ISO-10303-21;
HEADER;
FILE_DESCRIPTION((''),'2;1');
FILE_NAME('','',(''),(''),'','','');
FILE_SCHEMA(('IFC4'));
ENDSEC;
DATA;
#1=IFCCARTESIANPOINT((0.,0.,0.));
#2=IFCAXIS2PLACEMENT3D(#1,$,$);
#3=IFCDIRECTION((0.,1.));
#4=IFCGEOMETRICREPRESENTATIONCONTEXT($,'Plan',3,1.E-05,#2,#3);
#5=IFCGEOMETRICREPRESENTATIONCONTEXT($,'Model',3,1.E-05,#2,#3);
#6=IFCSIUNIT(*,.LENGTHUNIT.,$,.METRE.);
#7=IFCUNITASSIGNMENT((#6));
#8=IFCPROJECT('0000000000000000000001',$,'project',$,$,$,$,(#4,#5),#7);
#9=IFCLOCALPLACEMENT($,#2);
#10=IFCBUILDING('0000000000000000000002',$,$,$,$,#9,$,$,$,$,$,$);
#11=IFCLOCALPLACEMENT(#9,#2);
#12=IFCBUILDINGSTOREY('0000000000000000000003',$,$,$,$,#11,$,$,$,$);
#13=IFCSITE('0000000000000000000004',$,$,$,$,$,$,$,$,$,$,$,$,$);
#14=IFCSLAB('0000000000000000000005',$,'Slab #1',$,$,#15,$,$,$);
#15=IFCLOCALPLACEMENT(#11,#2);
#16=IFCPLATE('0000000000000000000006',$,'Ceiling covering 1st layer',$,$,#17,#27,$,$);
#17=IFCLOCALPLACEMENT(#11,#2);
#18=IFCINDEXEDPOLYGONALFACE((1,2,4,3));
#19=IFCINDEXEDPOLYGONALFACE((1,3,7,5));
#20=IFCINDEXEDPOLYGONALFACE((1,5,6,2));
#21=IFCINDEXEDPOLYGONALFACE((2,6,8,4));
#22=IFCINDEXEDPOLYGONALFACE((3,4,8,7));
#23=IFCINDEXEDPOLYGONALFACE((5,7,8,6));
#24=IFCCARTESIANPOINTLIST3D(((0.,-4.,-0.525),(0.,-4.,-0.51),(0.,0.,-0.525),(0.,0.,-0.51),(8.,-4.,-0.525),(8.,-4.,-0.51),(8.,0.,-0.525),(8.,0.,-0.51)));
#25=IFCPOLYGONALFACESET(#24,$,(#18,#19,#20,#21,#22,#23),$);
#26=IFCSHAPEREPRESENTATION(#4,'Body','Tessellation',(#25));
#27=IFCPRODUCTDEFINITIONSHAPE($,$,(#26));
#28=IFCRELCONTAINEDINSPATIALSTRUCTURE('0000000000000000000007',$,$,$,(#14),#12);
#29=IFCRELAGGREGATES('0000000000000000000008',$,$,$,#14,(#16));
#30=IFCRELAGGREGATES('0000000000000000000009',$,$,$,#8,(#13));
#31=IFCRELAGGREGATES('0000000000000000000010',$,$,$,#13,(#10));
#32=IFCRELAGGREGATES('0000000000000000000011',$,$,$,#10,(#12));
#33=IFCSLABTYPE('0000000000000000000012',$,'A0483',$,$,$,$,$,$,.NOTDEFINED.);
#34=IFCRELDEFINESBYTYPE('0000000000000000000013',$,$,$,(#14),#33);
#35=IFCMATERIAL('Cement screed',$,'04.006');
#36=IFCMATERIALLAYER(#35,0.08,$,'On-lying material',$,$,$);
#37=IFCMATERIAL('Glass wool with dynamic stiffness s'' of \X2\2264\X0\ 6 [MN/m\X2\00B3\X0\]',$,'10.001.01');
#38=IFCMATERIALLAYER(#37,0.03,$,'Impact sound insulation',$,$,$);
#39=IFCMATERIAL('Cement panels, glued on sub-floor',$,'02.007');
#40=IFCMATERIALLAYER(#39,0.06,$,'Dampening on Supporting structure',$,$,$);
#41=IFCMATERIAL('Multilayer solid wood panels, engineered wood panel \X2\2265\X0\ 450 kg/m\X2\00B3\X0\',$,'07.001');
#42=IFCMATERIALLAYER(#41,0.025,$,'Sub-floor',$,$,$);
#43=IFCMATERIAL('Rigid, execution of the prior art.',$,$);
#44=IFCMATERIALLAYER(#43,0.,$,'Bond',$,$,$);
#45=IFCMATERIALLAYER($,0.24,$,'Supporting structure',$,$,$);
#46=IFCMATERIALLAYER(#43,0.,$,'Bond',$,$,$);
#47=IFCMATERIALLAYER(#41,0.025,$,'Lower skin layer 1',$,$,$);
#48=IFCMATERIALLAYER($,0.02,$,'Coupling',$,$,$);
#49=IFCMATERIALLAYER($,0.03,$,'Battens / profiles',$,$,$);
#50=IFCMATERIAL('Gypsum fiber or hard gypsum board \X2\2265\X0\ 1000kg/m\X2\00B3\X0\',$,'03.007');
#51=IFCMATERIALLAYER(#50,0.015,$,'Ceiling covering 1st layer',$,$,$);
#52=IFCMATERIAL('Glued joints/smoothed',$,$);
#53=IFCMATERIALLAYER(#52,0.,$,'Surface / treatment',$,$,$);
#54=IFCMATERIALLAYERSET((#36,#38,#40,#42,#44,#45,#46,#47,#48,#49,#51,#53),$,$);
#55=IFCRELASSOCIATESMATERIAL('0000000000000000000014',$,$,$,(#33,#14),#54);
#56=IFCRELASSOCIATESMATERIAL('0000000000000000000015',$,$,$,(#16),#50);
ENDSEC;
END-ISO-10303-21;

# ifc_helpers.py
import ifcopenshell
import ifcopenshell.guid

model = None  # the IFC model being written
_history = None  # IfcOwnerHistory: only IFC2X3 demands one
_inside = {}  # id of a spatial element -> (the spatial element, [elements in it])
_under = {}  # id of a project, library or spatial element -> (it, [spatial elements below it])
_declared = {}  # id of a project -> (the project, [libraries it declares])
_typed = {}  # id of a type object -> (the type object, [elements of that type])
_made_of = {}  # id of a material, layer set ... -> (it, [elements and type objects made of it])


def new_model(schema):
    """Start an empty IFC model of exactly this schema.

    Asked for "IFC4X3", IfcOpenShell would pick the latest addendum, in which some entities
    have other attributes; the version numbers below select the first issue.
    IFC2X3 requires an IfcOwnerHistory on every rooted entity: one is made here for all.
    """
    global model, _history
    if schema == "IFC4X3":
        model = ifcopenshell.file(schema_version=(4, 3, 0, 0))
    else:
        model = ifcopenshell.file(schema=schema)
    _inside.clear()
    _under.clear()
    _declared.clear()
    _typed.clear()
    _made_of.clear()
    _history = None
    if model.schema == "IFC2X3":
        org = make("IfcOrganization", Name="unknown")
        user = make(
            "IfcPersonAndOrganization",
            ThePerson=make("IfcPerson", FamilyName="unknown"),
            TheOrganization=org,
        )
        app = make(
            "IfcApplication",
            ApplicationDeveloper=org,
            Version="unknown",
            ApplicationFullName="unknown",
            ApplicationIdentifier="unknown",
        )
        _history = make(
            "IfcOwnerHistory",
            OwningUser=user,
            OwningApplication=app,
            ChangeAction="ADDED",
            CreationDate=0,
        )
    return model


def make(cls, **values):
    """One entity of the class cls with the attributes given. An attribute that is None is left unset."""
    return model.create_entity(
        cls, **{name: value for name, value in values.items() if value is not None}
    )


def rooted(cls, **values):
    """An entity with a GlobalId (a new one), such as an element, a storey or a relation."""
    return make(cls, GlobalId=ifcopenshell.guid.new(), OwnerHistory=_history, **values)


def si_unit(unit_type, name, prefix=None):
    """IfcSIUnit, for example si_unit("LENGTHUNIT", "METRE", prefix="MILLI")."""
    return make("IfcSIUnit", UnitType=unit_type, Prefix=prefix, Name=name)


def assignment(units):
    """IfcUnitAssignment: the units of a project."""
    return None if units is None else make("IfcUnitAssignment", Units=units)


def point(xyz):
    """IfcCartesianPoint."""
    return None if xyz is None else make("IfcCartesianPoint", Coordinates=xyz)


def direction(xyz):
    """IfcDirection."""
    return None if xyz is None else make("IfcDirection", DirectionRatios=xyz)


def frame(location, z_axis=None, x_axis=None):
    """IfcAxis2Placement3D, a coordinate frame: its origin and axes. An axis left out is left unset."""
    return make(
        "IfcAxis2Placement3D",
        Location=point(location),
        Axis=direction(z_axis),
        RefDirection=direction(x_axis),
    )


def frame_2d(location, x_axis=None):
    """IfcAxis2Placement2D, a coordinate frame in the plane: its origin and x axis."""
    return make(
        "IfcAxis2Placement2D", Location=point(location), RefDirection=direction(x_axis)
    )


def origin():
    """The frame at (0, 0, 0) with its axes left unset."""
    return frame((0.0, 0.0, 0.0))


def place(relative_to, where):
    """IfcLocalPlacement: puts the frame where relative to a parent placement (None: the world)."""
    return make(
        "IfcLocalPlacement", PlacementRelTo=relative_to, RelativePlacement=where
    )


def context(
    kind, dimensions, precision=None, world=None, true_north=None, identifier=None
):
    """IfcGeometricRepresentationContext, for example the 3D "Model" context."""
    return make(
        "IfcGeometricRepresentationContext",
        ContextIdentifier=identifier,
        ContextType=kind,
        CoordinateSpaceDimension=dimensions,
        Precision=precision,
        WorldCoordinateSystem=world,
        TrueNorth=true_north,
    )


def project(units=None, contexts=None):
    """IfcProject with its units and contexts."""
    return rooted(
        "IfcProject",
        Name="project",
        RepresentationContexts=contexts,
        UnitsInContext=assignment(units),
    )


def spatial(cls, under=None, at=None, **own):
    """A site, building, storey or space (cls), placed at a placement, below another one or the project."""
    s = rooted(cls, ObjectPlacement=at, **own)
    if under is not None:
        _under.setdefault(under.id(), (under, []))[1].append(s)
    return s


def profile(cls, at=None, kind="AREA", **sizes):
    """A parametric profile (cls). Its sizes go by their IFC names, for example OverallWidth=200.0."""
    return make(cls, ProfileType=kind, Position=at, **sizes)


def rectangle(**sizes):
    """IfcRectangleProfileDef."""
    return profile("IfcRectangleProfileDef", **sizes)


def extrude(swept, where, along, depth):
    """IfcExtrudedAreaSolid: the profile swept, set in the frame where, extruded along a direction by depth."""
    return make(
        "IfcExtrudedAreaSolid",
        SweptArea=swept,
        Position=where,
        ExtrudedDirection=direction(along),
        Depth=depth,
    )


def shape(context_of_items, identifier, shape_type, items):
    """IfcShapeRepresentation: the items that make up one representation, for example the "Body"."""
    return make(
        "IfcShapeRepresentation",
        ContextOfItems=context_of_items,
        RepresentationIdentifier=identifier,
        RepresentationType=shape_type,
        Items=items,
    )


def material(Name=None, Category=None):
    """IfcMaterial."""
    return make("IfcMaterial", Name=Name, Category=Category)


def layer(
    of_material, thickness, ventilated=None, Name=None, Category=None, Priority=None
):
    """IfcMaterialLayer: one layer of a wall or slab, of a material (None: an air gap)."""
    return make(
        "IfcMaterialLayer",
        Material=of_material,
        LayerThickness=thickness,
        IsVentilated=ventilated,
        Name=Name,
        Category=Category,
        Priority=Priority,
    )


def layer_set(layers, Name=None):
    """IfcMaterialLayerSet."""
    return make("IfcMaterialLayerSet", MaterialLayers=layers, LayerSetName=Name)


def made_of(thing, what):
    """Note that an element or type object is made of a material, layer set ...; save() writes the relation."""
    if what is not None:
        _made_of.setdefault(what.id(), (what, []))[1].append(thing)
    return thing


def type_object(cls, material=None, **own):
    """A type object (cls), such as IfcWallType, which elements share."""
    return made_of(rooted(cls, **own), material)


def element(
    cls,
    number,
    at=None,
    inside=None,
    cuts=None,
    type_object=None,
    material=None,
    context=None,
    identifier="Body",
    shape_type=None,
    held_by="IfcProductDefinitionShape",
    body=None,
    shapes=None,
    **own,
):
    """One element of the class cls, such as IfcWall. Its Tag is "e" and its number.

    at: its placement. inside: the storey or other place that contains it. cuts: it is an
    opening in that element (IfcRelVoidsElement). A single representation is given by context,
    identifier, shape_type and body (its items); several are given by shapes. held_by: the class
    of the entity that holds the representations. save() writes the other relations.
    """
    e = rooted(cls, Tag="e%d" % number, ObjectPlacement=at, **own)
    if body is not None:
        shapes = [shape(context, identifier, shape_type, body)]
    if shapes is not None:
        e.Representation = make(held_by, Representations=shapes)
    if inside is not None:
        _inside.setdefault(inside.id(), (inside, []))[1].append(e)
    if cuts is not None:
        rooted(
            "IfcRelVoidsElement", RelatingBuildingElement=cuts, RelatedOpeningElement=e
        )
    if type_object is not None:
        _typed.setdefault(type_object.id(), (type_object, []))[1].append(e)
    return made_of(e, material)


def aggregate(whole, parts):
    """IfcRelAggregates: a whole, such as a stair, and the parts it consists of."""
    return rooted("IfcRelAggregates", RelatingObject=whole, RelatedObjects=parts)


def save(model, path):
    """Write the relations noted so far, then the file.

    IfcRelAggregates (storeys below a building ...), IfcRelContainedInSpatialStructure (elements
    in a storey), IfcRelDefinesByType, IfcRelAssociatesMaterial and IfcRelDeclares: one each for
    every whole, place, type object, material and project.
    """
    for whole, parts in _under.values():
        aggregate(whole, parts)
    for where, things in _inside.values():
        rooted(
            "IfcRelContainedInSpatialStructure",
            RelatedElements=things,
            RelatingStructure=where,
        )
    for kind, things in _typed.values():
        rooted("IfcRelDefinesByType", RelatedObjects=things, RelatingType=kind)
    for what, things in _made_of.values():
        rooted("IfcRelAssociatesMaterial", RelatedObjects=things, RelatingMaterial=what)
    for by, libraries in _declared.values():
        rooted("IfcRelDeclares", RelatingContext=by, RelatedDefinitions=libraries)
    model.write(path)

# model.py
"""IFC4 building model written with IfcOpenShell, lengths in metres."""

from ifc_helpers import new_model, si_unit, direction, frame, frame_2d, origin, place, context, project, spatial, rectangle, extrude, material, layer, layer_set, type_object, element, aggregate, save


model = new_model("IFC4")

# Units and contexts
plan_context = context("Plan", 3, precision=1e-05, world=origin(), true_north=direction((0.0, 1.0)))
model_context = context("Model", 3, precision=1e-05, world=origin(), true_north=direction((0.0, 1.0)))
ifc_project = project(units=[si_unit("LENGTHUNIT", "METRE")], contexts=[plan_context, model_context])

# Site, building, storey
site = spatial("IfcSite", under=ifc_project)
building_placement = place(None, origin())
building = spatial("IfcBuilding", under=site, at=building_placement)
storey_placement = place(building_placement, origin())
storey = spatial("IfcBuildingStorey", under=building, at=storey_placement)

# Slab, plate
ifc_material_1 = material(Name="Cement screed", Category="04.006")
ifc_layer_1 = layer(ifc_material_1, 0.08, Name="On-lying material")
ifc_material_2 = material(Name="Glass wool with dynamic stiffness s' of ≤ 6 [MN/m³]", Category="10.001.01")
ifc_layer_2 = layer(ifc_material_2, 0.03, Name="Impact sound insulation")
ifc_material_3 = material(Name="Cement panels, glued on sub-floor", Category="02.007")
ifc_layer_3 = layer(ifc_material_3, 0.06, Name="Dampening on Supporting structure")
ifc_material_4 = material(Name="Multilayer solid wood panels, engineered wood panel ≥ 450 kg/m³", Category="07.001")
ifc_layer_4 = layer(ifc_material_4, 0.025, Name="Sub-floor")
ifc_material_5 = material(Name="Rigid, execution of the prior art.")
ifc_layer_5 = layer(ifc_material_5, 0.0, Name="Bond")
ifc_layer_6 = layer(None, 0.24, Name="Supporting structure")
ifc_layer_7 = layer(ifc_material_5, 0.0, Name="Bond")
ifc_layer_8 = layer(ifc_material_4, 0.025, Name="Lower skin layer 1")
ifc_layer_9 = layer(None, 0.02, Name="Coupling")
ifc_layer_10 = layer(None, 0.03, Name="Battens / profiles")
ifc_material_6 = material(Name="Gypsum fiber or hard gypsum board ≥ 1000kg/m³", Category="03.007")
ifc_layer_11 = layer(ifc_material_6, 0.015, Name="Ceiling covering 1st layer")
ifc_material_7 = material(Name="Glued joints/smoothed")
ifc_layer_12 = layer(ifc_material_7, 0.0, Name="Surface / treatment")
ifc_layer_set = layer_set([ifc_layer_1, ifc_layer_2, ifc_layer_3, ifc_layer_4, ifc_layer_5, ifc_layer_6, ifc_layer_7, ifc_layer_8, ifc_layer_9, ifc_layer_10, ifc_layer_11, ifc_layer_12])
slab_type = type_object("IfcSlabType", Name="A0483", PredefinedType="NOTDEFINED", material=ifc_layer_set)
slab_placement = place(None, frame((0.0, 0.0, 0.0), z_axis=(0.0, 0.0, -1.0), x_axis=(1.0, 0.0, 0.0)))
slab = element("IfcSlab", 1, at=slab_placement, inside=storey, type_object=slab_type, material=ifc_layer_set, Name="Slab #1")
plate_1_placement = place(slab_placement, origin())
plate_1 = element("IfcPlate", 2, at=plate_1_placement, material=ifc_material_6, Name="Ceiling covering 1st layer", context=plan_context, shape_type="SweptSolid", body=[
    extrude(rectangle(XDim=8.0, YDim=4.0, at=frame_2d((4.0, 2.0), x_axis=(1.0, 0.0))), frame((0.0, 0.0, 0.51), z_axis=(0.0, 0.0, 1.0), x_axis=(1.0, 0.0, 0.0)), (0.0, 0.0, 1.0), 0.015),
])
aggregate(slab, [plate_1])

save(model, "model.ifc")
